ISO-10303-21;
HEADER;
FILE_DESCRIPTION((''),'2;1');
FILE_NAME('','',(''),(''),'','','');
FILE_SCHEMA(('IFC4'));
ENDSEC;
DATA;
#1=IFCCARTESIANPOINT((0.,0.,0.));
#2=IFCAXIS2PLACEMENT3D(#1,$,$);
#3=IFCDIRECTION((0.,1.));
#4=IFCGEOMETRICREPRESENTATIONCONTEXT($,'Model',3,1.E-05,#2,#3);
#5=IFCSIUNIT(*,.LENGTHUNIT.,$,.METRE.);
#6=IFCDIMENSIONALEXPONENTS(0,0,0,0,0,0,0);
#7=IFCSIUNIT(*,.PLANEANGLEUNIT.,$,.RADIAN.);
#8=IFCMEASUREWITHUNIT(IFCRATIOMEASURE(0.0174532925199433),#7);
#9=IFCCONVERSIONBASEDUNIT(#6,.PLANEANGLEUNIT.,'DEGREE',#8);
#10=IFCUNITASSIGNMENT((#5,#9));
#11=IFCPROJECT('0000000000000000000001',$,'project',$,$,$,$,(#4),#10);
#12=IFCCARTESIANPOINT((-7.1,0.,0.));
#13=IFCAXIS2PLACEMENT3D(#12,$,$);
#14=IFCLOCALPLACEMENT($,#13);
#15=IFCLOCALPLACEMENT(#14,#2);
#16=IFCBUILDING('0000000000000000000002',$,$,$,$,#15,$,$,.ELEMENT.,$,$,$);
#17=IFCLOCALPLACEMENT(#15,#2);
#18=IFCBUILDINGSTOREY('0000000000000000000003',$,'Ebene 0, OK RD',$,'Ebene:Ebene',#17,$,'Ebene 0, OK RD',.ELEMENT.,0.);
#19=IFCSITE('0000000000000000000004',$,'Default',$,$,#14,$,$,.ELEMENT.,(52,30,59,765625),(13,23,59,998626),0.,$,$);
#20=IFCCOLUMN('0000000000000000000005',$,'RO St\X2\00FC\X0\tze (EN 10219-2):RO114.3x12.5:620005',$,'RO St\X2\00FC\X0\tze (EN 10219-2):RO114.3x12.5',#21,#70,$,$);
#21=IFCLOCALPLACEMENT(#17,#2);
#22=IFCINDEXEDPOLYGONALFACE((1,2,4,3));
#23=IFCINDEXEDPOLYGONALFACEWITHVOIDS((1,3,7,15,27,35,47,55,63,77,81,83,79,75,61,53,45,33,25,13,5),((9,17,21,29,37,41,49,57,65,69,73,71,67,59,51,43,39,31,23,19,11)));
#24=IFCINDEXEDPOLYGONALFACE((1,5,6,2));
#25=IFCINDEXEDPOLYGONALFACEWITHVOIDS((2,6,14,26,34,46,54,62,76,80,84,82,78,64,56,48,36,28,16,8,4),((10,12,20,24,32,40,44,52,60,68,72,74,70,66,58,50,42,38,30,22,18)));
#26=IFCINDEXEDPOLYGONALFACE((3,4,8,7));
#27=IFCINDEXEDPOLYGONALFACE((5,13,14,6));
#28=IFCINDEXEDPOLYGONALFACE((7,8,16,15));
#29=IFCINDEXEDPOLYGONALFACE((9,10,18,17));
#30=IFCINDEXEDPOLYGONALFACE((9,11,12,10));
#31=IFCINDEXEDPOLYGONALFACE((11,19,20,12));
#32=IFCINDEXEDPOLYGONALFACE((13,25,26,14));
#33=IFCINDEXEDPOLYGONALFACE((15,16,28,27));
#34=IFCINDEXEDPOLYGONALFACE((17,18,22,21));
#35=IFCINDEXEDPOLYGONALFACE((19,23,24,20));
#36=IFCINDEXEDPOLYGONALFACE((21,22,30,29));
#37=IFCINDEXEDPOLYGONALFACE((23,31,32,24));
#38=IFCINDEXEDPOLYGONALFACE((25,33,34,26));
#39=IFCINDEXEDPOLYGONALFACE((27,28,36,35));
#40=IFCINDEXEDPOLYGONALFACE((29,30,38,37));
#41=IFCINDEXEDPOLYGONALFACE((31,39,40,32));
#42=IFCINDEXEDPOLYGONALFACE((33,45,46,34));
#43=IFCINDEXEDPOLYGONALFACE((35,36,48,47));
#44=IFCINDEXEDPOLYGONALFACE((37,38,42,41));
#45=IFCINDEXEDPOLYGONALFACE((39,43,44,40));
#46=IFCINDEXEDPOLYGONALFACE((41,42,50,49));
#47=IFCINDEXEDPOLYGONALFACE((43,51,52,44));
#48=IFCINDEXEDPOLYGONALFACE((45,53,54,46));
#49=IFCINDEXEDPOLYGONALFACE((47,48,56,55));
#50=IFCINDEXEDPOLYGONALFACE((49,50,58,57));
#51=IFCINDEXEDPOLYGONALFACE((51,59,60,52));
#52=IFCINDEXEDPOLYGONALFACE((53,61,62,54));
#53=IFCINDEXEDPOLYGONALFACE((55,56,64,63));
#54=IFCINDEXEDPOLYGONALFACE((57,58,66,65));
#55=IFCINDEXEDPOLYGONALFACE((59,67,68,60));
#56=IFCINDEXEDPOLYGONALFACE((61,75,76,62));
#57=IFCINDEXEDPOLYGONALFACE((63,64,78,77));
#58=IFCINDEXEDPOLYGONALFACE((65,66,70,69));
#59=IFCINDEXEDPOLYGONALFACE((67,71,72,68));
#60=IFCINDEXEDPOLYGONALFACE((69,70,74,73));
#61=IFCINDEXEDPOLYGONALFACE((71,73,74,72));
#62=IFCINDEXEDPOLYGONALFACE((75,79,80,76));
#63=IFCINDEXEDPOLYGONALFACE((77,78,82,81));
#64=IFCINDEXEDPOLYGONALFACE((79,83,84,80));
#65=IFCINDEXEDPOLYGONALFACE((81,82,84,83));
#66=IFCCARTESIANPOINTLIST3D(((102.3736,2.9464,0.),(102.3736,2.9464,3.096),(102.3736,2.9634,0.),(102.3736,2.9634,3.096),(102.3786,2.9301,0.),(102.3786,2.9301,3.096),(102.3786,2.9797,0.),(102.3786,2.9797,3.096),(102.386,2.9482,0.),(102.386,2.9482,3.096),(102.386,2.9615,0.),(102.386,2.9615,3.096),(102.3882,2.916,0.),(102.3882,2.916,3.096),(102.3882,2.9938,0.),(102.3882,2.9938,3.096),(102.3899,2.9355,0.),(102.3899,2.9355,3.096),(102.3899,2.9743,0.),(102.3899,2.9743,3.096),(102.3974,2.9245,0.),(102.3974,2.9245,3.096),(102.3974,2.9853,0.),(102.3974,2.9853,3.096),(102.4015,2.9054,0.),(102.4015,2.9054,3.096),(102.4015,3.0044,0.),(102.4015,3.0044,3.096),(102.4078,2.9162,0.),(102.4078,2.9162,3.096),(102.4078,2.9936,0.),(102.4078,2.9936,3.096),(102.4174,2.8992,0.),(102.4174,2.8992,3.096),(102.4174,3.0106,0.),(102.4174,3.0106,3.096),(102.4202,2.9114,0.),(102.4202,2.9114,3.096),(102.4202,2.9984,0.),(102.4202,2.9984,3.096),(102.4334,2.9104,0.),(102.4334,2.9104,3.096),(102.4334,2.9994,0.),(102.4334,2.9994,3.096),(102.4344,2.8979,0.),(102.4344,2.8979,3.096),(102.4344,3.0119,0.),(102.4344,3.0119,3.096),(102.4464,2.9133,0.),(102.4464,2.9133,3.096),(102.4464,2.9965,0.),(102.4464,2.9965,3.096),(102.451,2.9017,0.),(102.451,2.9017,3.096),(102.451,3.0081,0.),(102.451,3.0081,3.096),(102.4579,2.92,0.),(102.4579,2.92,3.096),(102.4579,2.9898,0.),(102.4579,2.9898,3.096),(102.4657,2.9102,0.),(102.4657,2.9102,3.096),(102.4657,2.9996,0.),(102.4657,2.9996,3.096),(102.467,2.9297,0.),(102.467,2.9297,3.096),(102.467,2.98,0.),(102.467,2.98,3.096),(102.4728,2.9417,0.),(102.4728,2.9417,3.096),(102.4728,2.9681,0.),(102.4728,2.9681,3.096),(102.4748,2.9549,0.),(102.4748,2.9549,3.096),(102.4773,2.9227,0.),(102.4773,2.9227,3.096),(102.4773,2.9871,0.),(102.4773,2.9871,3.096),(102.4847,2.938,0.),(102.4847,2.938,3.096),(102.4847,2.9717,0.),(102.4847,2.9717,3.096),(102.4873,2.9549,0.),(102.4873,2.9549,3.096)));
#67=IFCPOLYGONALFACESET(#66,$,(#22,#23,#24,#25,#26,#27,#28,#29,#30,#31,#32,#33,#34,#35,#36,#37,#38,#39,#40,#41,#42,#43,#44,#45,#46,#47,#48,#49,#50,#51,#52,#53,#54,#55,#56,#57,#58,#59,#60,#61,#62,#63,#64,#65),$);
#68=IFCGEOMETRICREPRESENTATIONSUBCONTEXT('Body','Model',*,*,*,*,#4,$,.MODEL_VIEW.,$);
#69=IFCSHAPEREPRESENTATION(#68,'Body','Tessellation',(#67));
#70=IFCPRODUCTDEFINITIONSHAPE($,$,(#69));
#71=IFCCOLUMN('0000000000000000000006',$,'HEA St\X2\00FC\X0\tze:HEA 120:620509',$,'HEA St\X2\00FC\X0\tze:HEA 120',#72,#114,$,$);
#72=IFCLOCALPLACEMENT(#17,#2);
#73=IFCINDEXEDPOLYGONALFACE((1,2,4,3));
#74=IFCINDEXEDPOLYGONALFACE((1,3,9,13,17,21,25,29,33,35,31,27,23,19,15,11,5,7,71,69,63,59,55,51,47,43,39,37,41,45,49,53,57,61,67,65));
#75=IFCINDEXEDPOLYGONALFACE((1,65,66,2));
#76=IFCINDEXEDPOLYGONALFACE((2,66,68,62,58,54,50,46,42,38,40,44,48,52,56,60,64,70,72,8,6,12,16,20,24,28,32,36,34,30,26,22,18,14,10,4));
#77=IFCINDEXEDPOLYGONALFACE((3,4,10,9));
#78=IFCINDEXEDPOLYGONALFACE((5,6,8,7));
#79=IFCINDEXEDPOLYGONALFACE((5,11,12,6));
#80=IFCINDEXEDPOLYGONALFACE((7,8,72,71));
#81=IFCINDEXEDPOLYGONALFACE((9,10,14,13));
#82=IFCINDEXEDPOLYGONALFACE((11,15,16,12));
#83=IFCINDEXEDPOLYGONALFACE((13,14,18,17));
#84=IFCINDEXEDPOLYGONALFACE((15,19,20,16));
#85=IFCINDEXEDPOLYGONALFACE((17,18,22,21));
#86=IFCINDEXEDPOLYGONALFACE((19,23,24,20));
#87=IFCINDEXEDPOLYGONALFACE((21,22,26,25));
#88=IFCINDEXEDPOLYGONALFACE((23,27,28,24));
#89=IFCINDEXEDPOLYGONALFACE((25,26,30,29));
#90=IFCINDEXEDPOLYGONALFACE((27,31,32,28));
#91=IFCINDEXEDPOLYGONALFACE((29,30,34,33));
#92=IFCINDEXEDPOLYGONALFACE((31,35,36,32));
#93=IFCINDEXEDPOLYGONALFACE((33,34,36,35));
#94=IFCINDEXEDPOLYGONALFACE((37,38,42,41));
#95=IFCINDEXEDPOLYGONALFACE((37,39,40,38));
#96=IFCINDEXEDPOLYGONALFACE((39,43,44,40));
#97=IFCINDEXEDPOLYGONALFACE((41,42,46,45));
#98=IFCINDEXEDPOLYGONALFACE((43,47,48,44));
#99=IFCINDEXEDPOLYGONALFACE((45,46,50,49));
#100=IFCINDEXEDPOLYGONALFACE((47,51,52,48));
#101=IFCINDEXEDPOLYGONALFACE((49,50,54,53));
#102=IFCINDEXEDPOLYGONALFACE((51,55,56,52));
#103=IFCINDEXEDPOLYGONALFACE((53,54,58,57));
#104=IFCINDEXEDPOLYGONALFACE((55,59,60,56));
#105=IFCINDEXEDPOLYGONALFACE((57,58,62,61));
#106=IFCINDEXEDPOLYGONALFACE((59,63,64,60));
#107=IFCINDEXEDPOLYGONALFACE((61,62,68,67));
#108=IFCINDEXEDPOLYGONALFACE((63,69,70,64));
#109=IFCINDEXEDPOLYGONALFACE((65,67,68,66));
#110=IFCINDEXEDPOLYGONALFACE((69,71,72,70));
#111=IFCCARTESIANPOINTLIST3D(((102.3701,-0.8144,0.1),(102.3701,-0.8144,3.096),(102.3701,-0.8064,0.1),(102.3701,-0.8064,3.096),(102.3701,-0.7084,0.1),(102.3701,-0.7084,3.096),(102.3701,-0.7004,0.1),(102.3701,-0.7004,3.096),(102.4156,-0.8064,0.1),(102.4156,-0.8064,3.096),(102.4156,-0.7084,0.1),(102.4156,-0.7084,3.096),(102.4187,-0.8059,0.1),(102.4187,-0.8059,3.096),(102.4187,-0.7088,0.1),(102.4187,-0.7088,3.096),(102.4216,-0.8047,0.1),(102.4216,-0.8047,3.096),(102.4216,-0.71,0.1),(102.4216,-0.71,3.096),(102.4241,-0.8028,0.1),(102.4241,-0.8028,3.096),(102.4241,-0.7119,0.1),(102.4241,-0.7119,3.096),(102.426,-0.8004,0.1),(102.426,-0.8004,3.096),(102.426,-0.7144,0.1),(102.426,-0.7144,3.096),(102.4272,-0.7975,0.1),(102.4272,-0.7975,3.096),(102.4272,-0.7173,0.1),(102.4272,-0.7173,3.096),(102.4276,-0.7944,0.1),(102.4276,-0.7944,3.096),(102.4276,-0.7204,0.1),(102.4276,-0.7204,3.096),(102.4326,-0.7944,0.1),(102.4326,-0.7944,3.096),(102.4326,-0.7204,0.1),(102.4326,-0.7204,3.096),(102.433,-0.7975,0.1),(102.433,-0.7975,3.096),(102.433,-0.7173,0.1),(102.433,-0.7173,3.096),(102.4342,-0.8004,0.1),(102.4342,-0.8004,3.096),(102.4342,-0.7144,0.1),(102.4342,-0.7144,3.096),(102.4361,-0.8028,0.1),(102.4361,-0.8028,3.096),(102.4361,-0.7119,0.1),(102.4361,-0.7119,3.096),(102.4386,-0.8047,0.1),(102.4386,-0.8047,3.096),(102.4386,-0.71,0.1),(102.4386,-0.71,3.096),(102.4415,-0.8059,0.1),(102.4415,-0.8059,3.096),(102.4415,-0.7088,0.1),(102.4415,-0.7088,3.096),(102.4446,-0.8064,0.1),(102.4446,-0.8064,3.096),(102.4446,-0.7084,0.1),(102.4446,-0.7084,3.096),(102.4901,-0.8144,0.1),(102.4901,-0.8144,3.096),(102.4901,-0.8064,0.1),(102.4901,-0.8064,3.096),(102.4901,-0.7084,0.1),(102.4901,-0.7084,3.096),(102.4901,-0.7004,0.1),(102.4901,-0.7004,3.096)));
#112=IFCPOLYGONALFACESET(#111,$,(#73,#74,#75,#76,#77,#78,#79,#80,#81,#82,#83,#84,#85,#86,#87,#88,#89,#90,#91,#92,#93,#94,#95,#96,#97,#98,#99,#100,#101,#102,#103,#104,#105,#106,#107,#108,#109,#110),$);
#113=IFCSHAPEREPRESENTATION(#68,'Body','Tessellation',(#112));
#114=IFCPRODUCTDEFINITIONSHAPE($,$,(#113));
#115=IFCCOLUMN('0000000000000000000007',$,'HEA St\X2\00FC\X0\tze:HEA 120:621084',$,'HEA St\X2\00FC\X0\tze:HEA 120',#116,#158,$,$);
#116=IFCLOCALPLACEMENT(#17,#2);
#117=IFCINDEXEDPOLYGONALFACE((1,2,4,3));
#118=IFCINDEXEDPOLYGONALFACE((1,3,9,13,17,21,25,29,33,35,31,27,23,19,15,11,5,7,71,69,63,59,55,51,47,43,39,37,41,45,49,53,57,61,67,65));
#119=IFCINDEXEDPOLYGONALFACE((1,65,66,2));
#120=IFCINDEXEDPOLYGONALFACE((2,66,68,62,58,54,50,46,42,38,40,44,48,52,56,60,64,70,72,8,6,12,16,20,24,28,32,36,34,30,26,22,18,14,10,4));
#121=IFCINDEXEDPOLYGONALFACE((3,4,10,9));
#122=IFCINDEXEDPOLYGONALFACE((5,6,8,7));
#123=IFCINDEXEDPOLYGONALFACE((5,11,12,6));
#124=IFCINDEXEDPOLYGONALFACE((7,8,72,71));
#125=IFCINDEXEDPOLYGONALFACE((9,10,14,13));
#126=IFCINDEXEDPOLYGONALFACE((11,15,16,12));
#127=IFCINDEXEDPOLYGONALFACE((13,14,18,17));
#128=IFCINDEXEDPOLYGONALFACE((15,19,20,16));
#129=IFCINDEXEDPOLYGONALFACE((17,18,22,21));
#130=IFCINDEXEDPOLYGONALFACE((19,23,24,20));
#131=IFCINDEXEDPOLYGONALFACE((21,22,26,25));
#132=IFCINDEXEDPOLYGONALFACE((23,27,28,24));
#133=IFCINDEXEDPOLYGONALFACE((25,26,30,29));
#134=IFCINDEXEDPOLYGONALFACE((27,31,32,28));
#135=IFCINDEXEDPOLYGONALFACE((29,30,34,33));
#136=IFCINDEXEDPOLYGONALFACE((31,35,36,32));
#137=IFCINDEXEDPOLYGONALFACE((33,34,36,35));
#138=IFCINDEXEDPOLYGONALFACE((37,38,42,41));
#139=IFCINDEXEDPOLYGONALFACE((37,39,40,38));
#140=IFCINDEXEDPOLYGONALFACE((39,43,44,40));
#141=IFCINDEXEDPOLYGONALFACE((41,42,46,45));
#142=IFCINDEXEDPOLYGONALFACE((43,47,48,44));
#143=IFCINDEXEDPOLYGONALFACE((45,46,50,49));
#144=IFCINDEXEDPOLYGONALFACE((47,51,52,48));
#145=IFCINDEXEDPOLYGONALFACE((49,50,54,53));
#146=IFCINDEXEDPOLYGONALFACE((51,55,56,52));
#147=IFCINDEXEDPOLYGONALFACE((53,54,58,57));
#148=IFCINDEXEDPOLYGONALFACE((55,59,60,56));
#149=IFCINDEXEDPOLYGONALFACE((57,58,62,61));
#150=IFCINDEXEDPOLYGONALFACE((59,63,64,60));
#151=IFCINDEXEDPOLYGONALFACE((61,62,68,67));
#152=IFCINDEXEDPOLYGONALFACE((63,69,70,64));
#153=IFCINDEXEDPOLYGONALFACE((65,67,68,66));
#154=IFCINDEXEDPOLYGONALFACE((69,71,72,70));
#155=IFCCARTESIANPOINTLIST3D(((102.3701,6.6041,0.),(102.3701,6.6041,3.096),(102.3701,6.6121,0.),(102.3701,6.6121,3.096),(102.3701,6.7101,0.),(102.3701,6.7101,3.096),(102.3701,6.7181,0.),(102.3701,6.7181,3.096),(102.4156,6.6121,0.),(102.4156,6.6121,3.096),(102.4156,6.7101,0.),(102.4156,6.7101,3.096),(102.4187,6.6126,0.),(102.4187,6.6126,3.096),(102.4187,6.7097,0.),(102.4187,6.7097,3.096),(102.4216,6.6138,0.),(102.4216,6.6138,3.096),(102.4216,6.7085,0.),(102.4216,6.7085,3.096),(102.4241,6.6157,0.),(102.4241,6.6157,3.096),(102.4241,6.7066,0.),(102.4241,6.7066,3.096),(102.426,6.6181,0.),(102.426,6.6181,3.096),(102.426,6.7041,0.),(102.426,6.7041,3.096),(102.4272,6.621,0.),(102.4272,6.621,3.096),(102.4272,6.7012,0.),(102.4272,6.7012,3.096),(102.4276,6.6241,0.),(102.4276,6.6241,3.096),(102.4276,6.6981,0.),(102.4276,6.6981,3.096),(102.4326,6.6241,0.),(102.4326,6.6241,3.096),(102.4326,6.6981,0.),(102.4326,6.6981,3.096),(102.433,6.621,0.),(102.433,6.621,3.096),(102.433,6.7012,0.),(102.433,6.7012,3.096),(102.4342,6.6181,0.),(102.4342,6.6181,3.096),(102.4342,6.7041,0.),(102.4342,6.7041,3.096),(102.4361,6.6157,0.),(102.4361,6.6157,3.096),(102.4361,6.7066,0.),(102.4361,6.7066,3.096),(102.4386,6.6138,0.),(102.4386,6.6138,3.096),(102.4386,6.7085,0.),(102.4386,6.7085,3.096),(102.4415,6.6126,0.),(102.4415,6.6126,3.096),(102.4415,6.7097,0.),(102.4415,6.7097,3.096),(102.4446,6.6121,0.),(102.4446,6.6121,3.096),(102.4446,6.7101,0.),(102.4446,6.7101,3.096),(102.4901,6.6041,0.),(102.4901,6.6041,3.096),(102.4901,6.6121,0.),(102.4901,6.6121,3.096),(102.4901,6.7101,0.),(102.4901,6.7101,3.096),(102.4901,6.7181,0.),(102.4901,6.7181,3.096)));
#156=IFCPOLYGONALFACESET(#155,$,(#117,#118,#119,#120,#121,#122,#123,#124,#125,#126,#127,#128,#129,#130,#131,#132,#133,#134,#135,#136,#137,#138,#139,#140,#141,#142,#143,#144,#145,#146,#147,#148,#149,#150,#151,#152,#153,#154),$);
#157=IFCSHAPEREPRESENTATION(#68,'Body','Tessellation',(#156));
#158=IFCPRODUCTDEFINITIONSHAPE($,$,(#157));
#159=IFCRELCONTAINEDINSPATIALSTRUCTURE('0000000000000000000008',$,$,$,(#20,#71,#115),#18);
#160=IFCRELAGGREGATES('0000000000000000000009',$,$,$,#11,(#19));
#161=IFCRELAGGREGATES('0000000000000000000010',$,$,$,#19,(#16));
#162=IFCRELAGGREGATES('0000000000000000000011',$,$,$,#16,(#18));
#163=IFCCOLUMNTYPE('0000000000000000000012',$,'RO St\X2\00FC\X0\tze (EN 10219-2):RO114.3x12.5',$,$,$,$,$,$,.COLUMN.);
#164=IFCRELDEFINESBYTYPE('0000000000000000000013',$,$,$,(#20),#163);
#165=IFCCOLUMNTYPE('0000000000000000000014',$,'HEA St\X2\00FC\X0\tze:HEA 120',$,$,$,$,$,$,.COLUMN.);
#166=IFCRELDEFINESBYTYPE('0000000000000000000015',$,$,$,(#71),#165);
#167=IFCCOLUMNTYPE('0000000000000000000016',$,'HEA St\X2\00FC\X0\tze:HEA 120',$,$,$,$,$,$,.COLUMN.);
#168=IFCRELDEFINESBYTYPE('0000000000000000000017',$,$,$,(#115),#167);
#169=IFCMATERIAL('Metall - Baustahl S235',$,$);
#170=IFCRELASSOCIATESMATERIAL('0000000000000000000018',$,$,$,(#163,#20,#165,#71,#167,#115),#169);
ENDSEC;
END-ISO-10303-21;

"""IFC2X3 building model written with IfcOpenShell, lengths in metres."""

from ifc_helpers import new_model, entity, si_unit, converted_unit, direction, frame, frame_2d, origin, place, context, subcontext, project, spatial, polyline, circle_curve, parameter, trimmed, segment, composite_curve, hollow_circle, outline, extrude, source, transform, mapped, material, type_object, type_shapes, element, save


model = new_model("IFC2X3")

# Units and contexts
model_context = context("Model", 3, precision=1e-05, world=origin(), true_north=direction((0.0, 1.0)))
body_context = subcontext(model_context, "Body", "Model", "MODEL_VIEW")
ifc_project = project(units=[si_unit("LENGTHUNIT", "METRE"), converted_unit("PLANEANGLEUNIT", "DEGREE", entity("IfcRatioMeasure", 0.0174532925199433), si_unit("PLANEANGLEUNIT", "RADIAN"), dimensions=[0, 0, 0, 0, 0, 0, 0])], contexts=[model_context])

# Site, building, storey
site_placement = place(None, frame((-7.1, 0.0, 0.0)))
site = spatial("IfcSite", under=ifc_project, at=site_placement, Name="Default", CompositionType="ELEMENT", RefLatitude=(52, 30, 59, 765625), RefLongitude=(13, 23, 59, 998626), RefElevation=0.0)
building_placement = place(site_placement, origin())
building = spatial("IfcBuilding", under=site, at=building_placement, CompositionType="ELEMENT")
storey_placement = place(building_placement, origin())
storey = spatial("IfcBuildingStorey", under=building, at=storey_placement, Name="Ebene 0, OK RD", ObjectType="Ebene:Ebene", LongName="Ebene 0, OK RD", CompositionType="ELEMENT", Elevation=0.0)

# Columns
ifc_material_1 = material(Name="Metall - Baustahl S235")
column_type_1 = type_object("IfcColumnType", Name="RO Stütze (EN 10219-2):RO114.3x12.5", PredefinedType="COLUMN", material=ifc_material_1)
shared_shape_1 = source(origin(), body_context, "Body", "SweptSolid", [
    extrude(hollow_circle(Radius=0.0571, WallThickness=0.0125, at=frame_2d((0.0, 0.0), x_axis=(1.0, 0.0))), origin(), (0.0, 0.0, 1.0), 3.096),
])
type_shapes(column_type_1, [shared_shape_1])
column_1_placement = place(storey_placement, frame((102.4301, 2.9549, 0.0)))
element("IfcColumn", 1, at=column_1_placement, inside=storey, type_object=column_type_1, material=ifc_material_1, Name="RO Stütze (EN 10219-2):RO114.3x12.5:620005", ObjectType="RO Stütze (EN 10219-2):RO114.3x12.5", context=body_context, shape_type="MappedRepresentation", body=[
    mapped(shared_shape_1, transform((0.0, 0.0, 0.0), scale=1.0)),
])
column_type_2 = type_object("IfcColumnType", Name="HEA Stütze:HEA 120", PredefinedType="COLUMN", material=ifc_material_1)
shared_shape_2 = source(origin(), body_context, "Body", "SweptSolid", [
    extrude(outline(composite_curve([segment(polyline([(0.049, -0.06), (0.057, -0.06)]), True, "CONTINUOUS"), segment(polyline([(0.057, -0.06), (0.057, 0.06)]), True, "CONTINUOUS"), segment(polyline([(0.057, 0.06), (0.049, 0.06)]), True, "CONTINUOUS"), segment(polyline([(0.049, 0.06), (0.049, 0.0145)]), True, "CONTINUOUS"), segment(trimmed(circle_curve(frame_2d((0.037, 0.0145), x_axis=(1.0, 0.0)), 0.012), [parameter(270.0)], [parameter(0.0)], True, "PARAMETER"), False, "CONTINUOUS"), segment(polyline([(0.037, 0.0025), (-0.037, 0.0025)]), True, "CONTINUOUS"), segment(trimmed(circle_curve(frame_2d((-0.037, 0.0145), x_axis=(0.0, -1.0)), 0.012), [parameter(270.0)], [parameter(0.0)], True, "PARAMETER"), False, "CONTINUOUS"), segment(polyline([(-0.049, 0.0145), (-0.049, 0.06)]), True, "CONTINUOUS"), segment(polyline([(-0.049, 0.06), (-0.057, 0.06)]), True, "CONTINUOUS"), segment(polyline([(-0.057, 0.06), (-0.057, -0.06)]), True, "CONTINUOUS"), segment(polyline([(-0.057, -0.06), (-0.049, -0.06)]), True, "CONTINUOUS"), segment(polyline([(-0.049, -0.06), (-0.049, -0.0145)]), True, "CONTINUOUS"), segment(trimmed(circle_curve(frame_2d((-0.037, -0.0145), x_axis=(-1.0, 0.0)), 0.012), [parameter(270.0)], [parameter(0.0)], True, "PARAMETER"), False, "CONTINUOUS"), segment(polyline([(-0.037, -0.0025), (0.037, -0.0025)]), True, "CONTINUOUS"), segment(trimmed(circle_curve(frame_2d((0.037, -0.0145), x_axis=(0.0, 1.0)), 0.012), [parameter(270.0)], [parameter(0.0)], True, "PARAMETER"), False, "CONTINUOUS"), segment(polyline([(0.049, -0.0145), (0.049, -0.06)]), True, "CONTINUOUS")], self_intersect=False)), frame((0.0, 0.0, 0.1), z_axis=(0.0, 0.0, 1.0), x_axis=(0.0, -1.0, 0.0)), (0.0, 0.0, 1.0), 2.996),
])
type_shapes(column_type_2, [shared_shape_2])
column_2_placement = place(storey_placement, frame((102.4301, -0.7574, 0.0), z_axis=(0.0, 0.0, 1.0), x_axis=(-1.0, 0.0, 0.0)))
element("IfcColumn", 2, at=column_2_placement, inside=storey, type_object=column_type_2, material=ifc_material_1, Name="HEA Stütze:HEA 120:620509", ObjectType="HEA Stütze:HEA 120", context=body_context, shape_type="MappedRepresentation", body=[
    mapped(shared_shape_2, transform((0.0, 0.0, 0.0), scale=1.0)),
])
column_type_3 = type_object("IfcColumnType", Name="HEA Stütze:HEA 120", PredefinedType="COLUMN", material=ifc_material_1)
shared_shape_3 = source(origin(), body_context, "Body", "SweptSolid", [
    extrude(outline(composite_curve([segment(polyline([(0.049, -0.06), (0.057, -0.06)]), True, "CONTINUOUS"), segment(polyline([(0.057, -0.06), (0.057, 0.06)]), True, "CONTINUOUS"), segment(polyline([(0.057, 0.06), (0.049, 0.06)]), True, "CONTINUOUS"), segment(polyline([(0.049, 0.06), (0.049, 0.0145)]), True, "CONTINUOUS"), segment(trimmed(circle_curve(frame_2d((0.037, 0.0145), x_axis=(1.0, 0.0)), 0.012), [parameter(270.0)], [parameter(0.0)], True, "PARAMETER"), False, "CONTINUOUS"), segment(polyline([(0.037, 0.0025), (-0.037, 0.0025)]), True, "CONTINUOUS"), segment(trimmed(circle_curve(frame_2d((-0.037, 0.0145), x_axis=(0.0, -1.0)), 0.012), [parameter(270.0)], [parameter(0.0)], True, "PARAMETER"), False, "CONTINUOUS"), segment(polyline([(-0.049, 0.0145), (-0.049, 0.06)]), True, "CONTINUOUS"), segment(polyline([(-0.049, 0.06), (-0.057, 0.06)]), True, "CONTINUOUS"), segment(polyline([(-0.057, 0.06), (-0.057, -0.06)]), True, "CONTINUOUS"), segment(polyline([(-0.057, -0.06), (-0.049, -0.06)]), True, "CONTINUOUS"), segment(polyline([(-0.049, -0.06), (-0.049, -0.0145)]), True, "CONTINUOUS"), segment(trimmed(circle_curve(frame_2d((-0.037, -0.0145), x_axis=(-1.0, 0.0)), 0.012), [parameter(270.0)], [parameter(0.0)], True, "PARAMETER"), False, "CONTINUOUS"), segment(polyline([(-0.037, -0.0025), (0.037, -0.0025)]), True, "CONTINUOUS"), segment(trimmed(circle_curve(frame_2d((0.037, -0.0145), x_axis=(0.0, 1.0)), 0.012), [parameter(270.0)], [parameter(0.0)], True, "PARAMETER"), False, "CONTINUOUS"), segment(polyline([(0.049, -0.0145), (0.049, -0.06)]), True, "CONTINUOUS")], self_intersect=False)), frame((0.0, 0.0, 0.0), z_axis=(0.0, 0.0, 1.0), x_axis=(0.0, -1.0, 0.0)), (0.0, 0.0, 1.0), 3.096),
])
type_shapes(column_type_3, [shared_shape_3])
column_3_placement = place(storey_placement, frame((102.4301, 6.6611, 0.0), z_axis=(0.0, 0.0, 1.0), x_axis=(-1.0, 0.0, 0.0)))
element("IfcColumn", 3, at=column_3_placement, inside=storey, type_object=column_type_3, material=ifc_material_1, Name="HEA Stütze:HEA 120:621084", ObjectType="HEA Stütze:HEA 120", context=body_context, shape_type="MappedRepresentation", body=[
    mapped(shared_shape_3, transform((0.0, 0.0, 0.0), scale=1.0)),
])

save(model, "model.ifc")
